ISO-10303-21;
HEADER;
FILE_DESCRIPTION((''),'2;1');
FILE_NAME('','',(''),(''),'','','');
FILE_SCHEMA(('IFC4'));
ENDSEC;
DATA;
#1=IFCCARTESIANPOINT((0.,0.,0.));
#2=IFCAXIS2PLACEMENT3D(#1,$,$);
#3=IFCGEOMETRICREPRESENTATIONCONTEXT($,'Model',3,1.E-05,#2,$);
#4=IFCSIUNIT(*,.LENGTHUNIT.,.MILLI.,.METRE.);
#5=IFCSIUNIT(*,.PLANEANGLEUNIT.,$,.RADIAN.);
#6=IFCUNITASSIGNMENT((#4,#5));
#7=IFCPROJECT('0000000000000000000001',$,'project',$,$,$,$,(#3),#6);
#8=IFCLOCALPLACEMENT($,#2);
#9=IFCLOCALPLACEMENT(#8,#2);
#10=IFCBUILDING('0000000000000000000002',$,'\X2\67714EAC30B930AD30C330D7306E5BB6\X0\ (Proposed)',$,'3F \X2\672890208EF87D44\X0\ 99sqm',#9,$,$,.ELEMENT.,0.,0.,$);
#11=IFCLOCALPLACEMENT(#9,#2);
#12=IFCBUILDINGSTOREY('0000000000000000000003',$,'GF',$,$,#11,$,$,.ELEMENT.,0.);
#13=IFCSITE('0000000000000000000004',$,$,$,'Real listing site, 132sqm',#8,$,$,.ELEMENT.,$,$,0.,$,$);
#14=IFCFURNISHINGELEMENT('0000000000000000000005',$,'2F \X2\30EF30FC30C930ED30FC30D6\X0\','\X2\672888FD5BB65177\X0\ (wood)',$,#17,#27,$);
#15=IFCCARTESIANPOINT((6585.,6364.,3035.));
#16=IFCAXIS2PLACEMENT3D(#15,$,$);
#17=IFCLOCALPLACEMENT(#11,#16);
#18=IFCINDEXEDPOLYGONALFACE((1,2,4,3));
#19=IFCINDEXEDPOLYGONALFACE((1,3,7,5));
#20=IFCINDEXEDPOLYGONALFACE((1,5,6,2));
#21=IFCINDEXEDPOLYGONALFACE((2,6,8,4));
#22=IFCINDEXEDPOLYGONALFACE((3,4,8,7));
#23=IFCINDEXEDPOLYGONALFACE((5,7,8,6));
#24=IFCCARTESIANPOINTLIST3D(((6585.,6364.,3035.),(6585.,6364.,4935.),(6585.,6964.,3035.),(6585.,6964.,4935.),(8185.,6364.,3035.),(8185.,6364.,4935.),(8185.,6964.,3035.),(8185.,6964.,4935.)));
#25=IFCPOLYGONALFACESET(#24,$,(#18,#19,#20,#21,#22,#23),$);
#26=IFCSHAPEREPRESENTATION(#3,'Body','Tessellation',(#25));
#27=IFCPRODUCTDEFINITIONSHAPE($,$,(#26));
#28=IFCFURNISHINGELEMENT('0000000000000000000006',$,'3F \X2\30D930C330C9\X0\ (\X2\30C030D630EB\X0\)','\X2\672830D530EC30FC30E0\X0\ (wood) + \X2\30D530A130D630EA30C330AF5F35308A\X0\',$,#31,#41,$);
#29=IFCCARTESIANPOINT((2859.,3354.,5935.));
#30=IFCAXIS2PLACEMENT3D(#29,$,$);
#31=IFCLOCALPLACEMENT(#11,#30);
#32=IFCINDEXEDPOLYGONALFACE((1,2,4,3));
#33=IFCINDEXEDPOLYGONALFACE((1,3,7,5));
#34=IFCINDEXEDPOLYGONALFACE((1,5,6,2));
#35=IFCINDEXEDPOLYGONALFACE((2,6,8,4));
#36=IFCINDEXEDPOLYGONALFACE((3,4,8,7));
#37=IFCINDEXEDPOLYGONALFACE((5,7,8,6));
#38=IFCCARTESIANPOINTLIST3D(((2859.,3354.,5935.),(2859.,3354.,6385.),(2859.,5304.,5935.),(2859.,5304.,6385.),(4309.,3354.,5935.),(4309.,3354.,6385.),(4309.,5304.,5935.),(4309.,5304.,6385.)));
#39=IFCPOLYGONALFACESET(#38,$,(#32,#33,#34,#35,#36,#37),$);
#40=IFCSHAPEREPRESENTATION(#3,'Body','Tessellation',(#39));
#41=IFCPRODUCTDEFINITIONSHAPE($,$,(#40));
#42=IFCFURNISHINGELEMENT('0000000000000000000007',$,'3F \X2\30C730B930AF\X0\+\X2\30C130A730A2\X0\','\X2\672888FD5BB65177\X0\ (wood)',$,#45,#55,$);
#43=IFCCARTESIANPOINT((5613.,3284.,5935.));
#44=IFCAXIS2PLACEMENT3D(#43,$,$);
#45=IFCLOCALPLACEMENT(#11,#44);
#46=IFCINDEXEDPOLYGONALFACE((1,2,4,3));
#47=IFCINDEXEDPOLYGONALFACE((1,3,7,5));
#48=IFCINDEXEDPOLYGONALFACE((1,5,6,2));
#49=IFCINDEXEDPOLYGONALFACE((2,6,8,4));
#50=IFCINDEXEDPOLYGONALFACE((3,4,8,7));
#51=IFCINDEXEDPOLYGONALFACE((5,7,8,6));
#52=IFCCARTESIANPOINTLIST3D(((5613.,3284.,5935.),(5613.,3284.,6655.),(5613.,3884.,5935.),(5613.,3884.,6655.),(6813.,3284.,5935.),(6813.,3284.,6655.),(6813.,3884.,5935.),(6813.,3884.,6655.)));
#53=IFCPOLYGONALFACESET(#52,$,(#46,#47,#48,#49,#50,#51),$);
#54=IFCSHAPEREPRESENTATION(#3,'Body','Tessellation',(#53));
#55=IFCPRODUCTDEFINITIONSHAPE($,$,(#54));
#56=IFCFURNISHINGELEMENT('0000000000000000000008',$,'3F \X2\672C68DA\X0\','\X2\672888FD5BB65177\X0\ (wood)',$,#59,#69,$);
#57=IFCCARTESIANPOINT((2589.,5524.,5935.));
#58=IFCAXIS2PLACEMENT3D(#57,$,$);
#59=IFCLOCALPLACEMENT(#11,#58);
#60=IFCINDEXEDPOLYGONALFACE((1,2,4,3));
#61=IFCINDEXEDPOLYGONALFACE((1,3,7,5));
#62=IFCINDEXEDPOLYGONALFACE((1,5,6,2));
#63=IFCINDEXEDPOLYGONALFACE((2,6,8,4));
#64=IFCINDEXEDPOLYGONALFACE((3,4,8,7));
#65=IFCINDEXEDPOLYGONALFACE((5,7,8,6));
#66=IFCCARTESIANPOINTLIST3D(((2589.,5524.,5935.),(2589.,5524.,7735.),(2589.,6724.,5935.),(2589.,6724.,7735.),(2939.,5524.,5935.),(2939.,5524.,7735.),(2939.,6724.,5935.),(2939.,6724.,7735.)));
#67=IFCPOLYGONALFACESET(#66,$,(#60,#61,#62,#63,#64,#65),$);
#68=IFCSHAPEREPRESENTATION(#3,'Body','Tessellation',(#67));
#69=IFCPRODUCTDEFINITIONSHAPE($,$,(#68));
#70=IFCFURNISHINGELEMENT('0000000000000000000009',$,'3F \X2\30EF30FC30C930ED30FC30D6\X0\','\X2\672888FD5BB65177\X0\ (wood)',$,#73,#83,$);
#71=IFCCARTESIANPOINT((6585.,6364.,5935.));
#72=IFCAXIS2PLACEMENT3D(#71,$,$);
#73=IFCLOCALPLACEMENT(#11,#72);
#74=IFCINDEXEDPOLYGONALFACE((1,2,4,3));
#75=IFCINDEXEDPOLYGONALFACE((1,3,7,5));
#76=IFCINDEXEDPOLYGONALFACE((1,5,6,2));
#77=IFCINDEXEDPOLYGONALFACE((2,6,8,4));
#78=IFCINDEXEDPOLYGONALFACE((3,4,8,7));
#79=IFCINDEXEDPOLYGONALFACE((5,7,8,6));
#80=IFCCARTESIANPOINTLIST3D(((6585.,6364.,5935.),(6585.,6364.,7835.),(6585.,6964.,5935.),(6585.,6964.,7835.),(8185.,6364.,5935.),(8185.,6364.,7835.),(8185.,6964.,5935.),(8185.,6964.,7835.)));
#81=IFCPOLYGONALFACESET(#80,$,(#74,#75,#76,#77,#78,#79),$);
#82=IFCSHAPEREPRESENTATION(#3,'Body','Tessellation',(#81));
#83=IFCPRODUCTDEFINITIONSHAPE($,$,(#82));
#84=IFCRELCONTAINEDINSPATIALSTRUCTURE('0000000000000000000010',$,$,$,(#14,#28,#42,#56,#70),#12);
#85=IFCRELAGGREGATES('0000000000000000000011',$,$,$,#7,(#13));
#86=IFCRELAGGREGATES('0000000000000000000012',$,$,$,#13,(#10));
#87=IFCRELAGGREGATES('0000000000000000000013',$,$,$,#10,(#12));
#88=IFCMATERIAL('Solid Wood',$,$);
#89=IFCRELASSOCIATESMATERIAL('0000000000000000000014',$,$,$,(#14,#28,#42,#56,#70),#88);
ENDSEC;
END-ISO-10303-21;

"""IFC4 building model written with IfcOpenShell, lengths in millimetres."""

from ifc_helpers import new_model, si_unit, frame, frame_2d, origin, place, context, project, spatial, rectangle, extrude, material, element, save


model = new_model("IFC4")

# Units and contexts
model_context = context("Model", 3, precision=1e-05, world=origin())
ifc_project = project(units=[si_unit("LENGTHUNIT", "METRE", prefix="MILLI"), si_unit("PLANEANGLEUNIT", "RADIAN")], contexts=[model_context])

# Site, building, storey
site_placement = place(None, origin())
site = spatial("IfcSite", under=ifc_project, at=site_placement, ObjectType="Real listing site, 132sqm", CompositionType="ELEMENT", RefElevation=0.0)
building_placement = place(site_placement, origin())
building = spatial("IfcBuilding", under=site, at=building_placement, Name="東京スキップの家 (Proposed)", ObjectType="3F 木造軸組 99sqm", CompositionType="ELEMENT", ElevationOfRefHeight=0.0, ElevationOfTerrain=0.0)
storey_placement = place(building_placement, origin())
storey = spatial("IfcBuildingStorey", under=building, at=storey_placement, Name="GF", CompositionType="ELEMENT", Elevation=0.0)

# Shared definitions
ifc_material_1 = material(Name="Solid Wood")

# Furnishing elements
furnishing_1_placement = place(storey_placement, frame((6585.0, 6364.0, 3035.0)))
element("IfcFurnishingElement", 1, at=furnishing_1_placement, inside=storey, material=ifc_material_1, Name="2F ワードローブ", Description="木製家具 (wood)", context=model_context, shape_type="SweptSolid", body=[
    extrude(rectangle(XDim=1600.0, YDim=600.0, at=frame_2d((800.0, 300.0))), frame((6585.0, 6364.0, 3035.0)), (0.0, 0.0, 1.0), 1900.0),
])
furnishing_2_placement = place(storey_placement, frame((2859.0, 3354.0, 5935.0)))
element("IfcFurnishingElement", 2, at=furnishing_2_placement, inside=storey, material=ifc_material_1, Name="3F ベッド (ダブル)", Description="木フレーム (wood) + ファブリック張り", context=model_context, shape_type="SweptSolid", body=[
    extrude(rectangle(XDim=1450.0, YDim=1950.0, at=frame_2d((725.0, 975.0))), frame((2859.0, 3354.0, 5935.0)), (0.0, 0.0, 1.0), 450.0),
])
furnishing_3_placement = place(storey_placement, frame((5613.0, 3284.0, 5935.0)))
element("IfcFurnishingElement", 3, at=furnishing_3_placement, inside=storey, material=ifc_material_1, Name="3F デスク+チェア", Description="木製家具 (wood)", context=model_context, shape_type="SweptSolid", body=[
    extrude(rectangle(XDim=1200.0, YDim=600.0, at=frame_2d((600.0, 300.0))), frame((5613.0, 3284.0, 5935.0)), (0.0, 0.0, 1.0), 720.0),
])
furnishing_4_placement = place(storey_placement, frame((2589.0, 5524.0, 5935.0)))
element("IfcFurnishingElement", 4, at=furnishing_4_placement, inside=storey, material=ifc_material_1, Name="3F 本棚", Description="木製家具 (wood)", context=model_context, shape_type="SweptSolid", body=[
    extrude(rectangle(XDim=350.0, YDim=1200.0, at=frame_2d((175.0, 600.0))), frame((2589.0, 5524.0, 5935.0)), (0.0, 0.0, 1.0), 1800.0),
])
furnishing_5_placement = place(storey_placement, frame((6585.0, 6364.0, 5935.0)))
element("IfcFurnishingElement", 5, at=furnishing_5_placement, inside=storey, material=ifc_material_1, Name="3F ワードローブ", Description="木製家具 (wood)", context=model_context, shape_type="SweptSolid", body=[
    extrude(rectangle(XDim=1600.0, YDim=600.0, at=frame_2d((800.0, 300.0))), frame((6585.0, 6364.0, 5935.0)), (0.0, 0.0, 1.0), 1900.0),
])

save(model, "model.ifc")
